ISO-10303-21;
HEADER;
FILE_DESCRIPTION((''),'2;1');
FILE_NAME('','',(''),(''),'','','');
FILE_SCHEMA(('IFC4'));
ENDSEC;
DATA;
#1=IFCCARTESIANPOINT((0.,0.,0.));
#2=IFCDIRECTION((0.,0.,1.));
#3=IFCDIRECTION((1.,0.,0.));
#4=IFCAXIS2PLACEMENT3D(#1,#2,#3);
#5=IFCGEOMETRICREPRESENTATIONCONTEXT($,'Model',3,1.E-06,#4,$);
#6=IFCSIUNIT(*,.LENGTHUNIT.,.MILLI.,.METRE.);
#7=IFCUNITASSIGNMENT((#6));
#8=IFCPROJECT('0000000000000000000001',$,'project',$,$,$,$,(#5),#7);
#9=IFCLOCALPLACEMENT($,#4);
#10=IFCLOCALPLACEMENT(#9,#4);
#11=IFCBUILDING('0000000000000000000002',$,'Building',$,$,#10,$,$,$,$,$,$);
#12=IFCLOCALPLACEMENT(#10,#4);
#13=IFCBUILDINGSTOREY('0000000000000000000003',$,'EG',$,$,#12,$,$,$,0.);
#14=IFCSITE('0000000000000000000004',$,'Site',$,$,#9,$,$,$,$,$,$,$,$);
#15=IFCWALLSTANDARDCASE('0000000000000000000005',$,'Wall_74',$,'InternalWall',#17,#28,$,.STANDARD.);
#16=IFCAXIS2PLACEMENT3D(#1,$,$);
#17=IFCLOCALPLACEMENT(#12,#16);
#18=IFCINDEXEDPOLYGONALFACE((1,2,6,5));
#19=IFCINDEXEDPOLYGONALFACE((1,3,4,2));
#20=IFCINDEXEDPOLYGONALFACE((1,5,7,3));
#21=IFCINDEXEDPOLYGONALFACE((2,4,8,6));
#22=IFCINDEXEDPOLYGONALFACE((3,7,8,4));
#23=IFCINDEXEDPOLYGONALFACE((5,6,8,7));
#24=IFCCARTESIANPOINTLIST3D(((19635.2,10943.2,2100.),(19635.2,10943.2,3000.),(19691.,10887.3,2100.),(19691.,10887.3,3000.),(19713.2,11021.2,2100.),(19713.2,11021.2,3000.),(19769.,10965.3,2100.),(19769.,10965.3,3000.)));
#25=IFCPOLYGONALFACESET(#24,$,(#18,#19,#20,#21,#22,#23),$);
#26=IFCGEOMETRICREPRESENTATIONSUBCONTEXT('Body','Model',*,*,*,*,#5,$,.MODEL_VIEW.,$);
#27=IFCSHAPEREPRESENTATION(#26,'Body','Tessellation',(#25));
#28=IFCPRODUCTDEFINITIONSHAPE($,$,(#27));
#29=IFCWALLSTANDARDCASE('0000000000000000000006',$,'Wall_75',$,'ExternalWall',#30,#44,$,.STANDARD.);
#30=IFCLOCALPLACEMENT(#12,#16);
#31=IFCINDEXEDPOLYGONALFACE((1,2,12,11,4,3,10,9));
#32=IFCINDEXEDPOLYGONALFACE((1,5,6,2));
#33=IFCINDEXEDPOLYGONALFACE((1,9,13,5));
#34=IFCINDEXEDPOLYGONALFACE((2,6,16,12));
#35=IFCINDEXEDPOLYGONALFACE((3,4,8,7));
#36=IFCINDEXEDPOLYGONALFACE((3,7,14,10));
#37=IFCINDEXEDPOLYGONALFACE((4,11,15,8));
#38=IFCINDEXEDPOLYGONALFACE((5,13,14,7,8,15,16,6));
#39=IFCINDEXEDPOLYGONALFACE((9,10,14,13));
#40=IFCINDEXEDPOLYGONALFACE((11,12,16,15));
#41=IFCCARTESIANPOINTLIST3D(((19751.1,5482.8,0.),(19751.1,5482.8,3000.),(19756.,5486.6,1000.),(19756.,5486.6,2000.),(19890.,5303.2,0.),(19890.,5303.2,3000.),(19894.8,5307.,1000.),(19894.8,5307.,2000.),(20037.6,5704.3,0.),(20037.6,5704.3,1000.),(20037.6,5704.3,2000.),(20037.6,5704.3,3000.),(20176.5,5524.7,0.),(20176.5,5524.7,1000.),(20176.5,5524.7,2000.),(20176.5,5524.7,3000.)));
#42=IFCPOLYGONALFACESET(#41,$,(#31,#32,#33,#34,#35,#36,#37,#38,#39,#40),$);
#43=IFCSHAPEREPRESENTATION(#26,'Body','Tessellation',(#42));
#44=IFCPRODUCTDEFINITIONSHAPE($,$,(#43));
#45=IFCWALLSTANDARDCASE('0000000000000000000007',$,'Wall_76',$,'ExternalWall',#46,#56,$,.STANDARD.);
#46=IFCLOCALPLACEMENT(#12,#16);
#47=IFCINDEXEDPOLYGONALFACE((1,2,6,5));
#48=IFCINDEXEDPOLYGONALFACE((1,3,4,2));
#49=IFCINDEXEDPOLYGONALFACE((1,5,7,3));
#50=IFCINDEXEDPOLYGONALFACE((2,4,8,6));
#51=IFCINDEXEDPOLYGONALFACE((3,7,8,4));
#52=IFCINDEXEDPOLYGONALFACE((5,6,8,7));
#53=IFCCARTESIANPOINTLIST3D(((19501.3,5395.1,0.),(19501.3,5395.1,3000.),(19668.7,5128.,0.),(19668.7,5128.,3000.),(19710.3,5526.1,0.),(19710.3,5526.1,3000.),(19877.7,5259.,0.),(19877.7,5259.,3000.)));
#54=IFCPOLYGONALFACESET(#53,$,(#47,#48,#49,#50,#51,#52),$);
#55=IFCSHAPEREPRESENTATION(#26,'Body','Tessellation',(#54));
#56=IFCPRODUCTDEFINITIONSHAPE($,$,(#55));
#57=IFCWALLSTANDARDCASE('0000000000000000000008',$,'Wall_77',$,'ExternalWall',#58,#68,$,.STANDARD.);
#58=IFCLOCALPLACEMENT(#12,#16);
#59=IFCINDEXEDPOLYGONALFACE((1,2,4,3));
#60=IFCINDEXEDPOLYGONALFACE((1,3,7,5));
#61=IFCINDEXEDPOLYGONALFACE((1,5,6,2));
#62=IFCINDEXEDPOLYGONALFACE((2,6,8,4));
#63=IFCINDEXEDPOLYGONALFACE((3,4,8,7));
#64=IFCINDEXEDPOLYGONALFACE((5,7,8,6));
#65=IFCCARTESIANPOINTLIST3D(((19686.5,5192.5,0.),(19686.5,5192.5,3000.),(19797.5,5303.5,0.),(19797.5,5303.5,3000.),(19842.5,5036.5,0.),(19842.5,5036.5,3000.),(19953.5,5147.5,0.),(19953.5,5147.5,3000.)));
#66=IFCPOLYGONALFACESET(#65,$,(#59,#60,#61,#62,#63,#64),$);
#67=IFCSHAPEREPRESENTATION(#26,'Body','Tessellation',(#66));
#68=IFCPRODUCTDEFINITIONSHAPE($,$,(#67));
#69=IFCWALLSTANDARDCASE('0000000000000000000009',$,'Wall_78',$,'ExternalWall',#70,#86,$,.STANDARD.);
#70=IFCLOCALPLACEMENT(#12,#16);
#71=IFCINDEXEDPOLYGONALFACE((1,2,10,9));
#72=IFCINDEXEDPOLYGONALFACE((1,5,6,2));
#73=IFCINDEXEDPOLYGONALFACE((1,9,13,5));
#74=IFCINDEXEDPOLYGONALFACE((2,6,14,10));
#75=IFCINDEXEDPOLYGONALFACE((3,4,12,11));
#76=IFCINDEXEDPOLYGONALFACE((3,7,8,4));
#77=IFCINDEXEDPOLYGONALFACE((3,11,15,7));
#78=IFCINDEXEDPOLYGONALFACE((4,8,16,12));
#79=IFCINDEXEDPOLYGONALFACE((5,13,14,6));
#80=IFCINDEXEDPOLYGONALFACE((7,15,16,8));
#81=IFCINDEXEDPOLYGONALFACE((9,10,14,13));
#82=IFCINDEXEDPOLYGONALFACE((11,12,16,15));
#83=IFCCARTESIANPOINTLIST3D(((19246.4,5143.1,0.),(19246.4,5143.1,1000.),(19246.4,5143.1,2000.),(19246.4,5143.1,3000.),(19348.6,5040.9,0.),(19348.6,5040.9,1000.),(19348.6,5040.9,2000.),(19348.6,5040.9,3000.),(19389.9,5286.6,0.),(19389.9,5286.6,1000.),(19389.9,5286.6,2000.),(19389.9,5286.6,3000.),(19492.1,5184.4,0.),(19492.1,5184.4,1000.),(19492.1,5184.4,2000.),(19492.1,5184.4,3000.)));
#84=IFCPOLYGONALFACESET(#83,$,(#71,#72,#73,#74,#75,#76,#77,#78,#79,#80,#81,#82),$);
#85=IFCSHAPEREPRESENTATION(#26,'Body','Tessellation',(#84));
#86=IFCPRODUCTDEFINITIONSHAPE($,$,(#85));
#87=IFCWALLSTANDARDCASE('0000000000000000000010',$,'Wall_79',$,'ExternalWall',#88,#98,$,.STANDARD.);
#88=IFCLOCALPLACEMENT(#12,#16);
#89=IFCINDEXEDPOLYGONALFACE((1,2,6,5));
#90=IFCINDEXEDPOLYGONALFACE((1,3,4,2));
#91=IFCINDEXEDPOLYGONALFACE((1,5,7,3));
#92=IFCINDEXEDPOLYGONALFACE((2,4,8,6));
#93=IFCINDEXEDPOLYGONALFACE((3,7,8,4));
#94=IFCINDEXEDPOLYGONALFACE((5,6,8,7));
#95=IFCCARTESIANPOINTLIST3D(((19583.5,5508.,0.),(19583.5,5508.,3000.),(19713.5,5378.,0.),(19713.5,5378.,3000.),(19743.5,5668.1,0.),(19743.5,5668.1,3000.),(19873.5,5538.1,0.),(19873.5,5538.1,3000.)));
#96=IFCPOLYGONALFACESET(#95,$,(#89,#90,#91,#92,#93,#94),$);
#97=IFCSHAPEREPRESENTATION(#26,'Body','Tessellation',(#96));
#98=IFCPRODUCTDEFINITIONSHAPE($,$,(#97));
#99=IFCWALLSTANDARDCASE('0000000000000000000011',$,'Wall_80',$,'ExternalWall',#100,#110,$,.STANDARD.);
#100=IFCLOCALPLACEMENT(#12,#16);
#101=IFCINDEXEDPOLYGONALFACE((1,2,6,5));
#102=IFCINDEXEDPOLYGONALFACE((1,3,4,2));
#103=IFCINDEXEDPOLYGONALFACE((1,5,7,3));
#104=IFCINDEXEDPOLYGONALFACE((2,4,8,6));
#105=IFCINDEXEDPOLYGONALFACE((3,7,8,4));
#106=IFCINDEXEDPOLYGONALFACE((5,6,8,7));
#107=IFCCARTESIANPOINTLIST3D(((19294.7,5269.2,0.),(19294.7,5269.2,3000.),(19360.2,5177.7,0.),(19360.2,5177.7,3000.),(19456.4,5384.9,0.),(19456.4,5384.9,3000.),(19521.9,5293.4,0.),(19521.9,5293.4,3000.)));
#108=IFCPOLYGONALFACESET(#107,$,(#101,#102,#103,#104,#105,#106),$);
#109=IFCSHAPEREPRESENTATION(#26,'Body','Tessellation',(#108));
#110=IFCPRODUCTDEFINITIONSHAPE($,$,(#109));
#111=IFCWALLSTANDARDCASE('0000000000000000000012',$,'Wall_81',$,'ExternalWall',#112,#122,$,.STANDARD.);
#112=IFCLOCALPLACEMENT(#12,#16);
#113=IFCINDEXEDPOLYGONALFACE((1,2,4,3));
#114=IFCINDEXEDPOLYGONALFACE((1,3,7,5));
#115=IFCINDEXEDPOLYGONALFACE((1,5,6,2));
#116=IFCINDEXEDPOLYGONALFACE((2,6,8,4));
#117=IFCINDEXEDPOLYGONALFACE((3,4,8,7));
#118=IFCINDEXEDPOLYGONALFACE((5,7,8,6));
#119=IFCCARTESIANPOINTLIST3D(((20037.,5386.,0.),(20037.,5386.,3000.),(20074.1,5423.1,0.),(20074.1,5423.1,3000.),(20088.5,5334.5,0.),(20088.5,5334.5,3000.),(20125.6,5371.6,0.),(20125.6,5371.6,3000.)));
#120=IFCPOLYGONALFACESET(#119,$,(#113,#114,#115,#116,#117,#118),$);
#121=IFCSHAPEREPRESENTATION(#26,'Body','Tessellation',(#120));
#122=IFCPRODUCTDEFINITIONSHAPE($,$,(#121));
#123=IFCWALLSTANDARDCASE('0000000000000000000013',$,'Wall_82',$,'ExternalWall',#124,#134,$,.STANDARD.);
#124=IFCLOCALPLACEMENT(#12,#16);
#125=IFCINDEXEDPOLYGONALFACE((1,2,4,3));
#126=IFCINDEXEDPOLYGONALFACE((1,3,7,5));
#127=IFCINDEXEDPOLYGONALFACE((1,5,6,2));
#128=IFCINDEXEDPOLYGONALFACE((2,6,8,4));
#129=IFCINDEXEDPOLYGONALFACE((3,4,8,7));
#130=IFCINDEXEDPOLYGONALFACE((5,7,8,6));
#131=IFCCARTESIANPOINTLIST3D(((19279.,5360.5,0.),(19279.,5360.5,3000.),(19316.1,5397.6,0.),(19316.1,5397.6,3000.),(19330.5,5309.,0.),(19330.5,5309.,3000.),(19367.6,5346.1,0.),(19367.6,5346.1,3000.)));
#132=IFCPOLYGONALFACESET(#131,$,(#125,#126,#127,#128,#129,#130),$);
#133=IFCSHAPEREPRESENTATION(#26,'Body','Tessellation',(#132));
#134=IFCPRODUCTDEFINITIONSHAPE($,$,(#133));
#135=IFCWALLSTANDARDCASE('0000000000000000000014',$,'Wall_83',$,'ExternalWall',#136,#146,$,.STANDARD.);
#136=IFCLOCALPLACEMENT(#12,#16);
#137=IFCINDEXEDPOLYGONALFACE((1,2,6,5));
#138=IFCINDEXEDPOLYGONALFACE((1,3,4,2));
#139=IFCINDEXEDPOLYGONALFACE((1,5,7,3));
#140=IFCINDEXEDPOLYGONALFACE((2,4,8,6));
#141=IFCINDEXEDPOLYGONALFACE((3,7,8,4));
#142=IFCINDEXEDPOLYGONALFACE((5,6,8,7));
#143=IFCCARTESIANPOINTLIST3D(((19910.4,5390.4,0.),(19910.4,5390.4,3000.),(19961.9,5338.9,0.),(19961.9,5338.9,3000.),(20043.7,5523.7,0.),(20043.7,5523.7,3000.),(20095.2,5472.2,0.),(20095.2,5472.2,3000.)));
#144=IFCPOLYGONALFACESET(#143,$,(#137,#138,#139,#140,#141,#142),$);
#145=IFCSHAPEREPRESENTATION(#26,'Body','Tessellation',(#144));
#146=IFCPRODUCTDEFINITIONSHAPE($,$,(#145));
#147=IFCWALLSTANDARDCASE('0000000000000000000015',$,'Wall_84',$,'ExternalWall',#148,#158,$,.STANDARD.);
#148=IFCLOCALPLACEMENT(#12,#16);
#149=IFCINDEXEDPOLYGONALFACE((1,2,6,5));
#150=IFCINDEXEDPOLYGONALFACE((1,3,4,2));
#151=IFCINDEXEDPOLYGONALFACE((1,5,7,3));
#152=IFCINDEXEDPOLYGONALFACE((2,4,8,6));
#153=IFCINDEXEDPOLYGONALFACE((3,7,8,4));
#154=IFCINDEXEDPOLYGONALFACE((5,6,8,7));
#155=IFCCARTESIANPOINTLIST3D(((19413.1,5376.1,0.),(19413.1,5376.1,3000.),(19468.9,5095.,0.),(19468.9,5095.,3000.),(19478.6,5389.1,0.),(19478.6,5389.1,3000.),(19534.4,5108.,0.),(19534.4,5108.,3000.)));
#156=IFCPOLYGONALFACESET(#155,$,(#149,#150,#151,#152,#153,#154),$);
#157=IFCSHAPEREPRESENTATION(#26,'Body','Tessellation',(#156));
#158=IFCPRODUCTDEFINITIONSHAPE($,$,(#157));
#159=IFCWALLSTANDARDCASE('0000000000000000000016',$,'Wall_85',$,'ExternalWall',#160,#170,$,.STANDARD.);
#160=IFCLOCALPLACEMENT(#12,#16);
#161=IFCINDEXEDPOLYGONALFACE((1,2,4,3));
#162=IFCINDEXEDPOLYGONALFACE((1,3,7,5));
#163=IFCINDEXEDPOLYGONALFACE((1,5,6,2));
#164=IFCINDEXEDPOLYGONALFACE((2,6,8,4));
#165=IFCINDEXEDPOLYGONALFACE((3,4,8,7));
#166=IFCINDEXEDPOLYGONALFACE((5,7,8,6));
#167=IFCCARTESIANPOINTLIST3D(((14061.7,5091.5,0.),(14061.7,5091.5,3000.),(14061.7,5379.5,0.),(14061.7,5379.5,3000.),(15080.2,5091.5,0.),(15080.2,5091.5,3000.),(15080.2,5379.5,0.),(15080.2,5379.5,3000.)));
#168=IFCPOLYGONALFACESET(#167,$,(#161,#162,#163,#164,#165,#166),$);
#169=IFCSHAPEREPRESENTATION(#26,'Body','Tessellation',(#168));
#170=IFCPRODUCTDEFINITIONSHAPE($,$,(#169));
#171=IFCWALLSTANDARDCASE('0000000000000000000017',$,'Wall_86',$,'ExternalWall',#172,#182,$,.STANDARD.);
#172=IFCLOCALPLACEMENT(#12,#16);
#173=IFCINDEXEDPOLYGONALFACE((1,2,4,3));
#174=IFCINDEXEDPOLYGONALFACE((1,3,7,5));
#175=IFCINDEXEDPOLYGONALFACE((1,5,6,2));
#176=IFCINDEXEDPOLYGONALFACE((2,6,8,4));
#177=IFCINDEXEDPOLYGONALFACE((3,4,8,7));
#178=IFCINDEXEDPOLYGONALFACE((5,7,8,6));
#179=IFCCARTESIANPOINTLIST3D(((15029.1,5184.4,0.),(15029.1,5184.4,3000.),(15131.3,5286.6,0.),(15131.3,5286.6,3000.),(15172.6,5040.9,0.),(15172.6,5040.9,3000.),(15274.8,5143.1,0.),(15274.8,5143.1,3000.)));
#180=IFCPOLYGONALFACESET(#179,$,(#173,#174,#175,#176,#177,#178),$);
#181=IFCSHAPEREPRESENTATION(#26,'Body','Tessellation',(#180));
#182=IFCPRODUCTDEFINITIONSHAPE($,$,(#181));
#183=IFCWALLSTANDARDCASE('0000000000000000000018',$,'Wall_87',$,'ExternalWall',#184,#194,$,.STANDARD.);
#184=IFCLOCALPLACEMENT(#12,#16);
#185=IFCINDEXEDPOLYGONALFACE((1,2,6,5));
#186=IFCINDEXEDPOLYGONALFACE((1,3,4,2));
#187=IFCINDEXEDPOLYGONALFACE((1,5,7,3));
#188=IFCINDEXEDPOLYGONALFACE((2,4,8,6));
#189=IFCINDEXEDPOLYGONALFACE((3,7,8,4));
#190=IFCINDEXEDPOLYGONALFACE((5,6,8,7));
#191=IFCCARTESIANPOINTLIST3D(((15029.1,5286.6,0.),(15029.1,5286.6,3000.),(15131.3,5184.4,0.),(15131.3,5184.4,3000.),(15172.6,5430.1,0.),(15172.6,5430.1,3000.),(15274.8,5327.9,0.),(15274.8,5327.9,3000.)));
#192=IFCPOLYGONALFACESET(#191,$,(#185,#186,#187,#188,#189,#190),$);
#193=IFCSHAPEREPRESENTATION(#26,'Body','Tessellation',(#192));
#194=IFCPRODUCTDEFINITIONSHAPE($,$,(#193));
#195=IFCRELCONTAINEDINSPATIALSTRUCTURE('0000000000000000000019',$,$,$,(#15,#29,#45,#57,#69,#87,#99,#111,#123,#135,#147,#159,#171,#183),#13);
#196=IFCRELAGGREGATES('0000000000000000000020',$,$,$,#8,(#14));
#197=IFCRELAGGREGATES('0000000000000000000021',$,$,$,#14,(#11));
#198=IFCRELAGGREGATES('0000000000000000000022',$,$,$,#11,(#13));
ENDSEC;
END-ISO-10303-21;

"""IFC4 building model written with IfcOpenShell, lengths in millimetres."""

from ifc_helpers import new_model, si_unit, frame, origin_with_axes, place, context, subcontext, project, spatial, rectangle, extrude, element, save


model = new_model("IFC4")

# Units and contexts
model_context = context("Model", 3, precision=1e-06, world=origin_with_axes())
body_context = subcontext(model_context, "Body", "Model", "MODEL_VIEW")
ifc_project = project(units=[si_unit("LENGTHUNIT", "METRE", prefix="MILLI")], contexts=[model_context])

# Site, building, storey
site_placement = place(None, origin_with_axes())
site = spatial("IfcSite", under=ifc_project, at=site_placement, Name="Site")
building_placement = place(site_placement, origin_with_axes())
building = spatial("IfcBuilding", under=site, at=building_placement, Name="Building")
storey_placement = place(building_placement, origin_with_axes())
storey = spatial("IfcBuildingStorey", under=building, at=storey_placement, Name="EG", Elevation=0.0)

# Walls, openings
wall_1_placement = place(storey_placement, origin_with_axes())
wall_1 = element("IfcWallStandardCase", 1, at=wall_1_placement, inside=storey, Name="Wall_74", ObjectType="InternalWall", PredefinedType="STANDARD", context=body_context, shape_type="SweptSolid", body=[
    extrude(rectangle(XDim=110.3, YDim=79.0), frame((19702.1, 10954.2, 0.0), z_axis=(0.0, 0.0, 1.0), x_axis=(-0.707107, -0.707107, 0.0)), (0.0, 0.0, 1.0), 3000.0),
])
opening_1_placement = place(wall_1_placement, origin_with_axes())
element("IfcOpeningElement", 2, at=opening_1_placement, inside=storey, cuts=wall_1, context=body_context, shape_type="SweptSolid", body=[
    extrude(rectangle(XDim=450.0, YDim=79.0), frame((19702.1, 10954.2, 0.0), z_axis=(0.0, 0.0, 1.0), x_axis=(-0.707107, -0.707107, 0.0)), (0.0, 0.0, 1.0), 2100.0),
])
wall_2_placement = place(storey_placement, origin_with_axes())
wall_2 = element("IfcWallStandardCase", 3, at=wall_2_placement, inside=storey, Name="Wall_75", ObjectType="ExternalWall", PredefinedType="STANDARD", context=body_context, shape_type="SweptSolid", body=[
    extrude(rectangle(XDim=362.1, YDim=227.0), frame((19963.8, 5503.8, 0.0), z_axis=(0.0, 0.0, 1.0), x_axis=(-0.791133, -0.611644, 0.0)), (0.0, 0.0, 1.0), 3000.0),
])
opening_2_placement = place(wall_2_placement, origin_with_axes())
element("IfcOpeningElement", 4, at=opening_2_placement, inside=storey, cuts=wall_2, context=body_context, shape_type="SweptSolid", body=[
    extrude(rectangle(XDim=600.0, YDim=227.0), frame((20062.7, 5580.3, 1000.0), z_axis=(0.0, 0.0, 1.0), x_axis=(-0.791133, -0.611644, 0.0)), (0.0, 0.0, 1.0), 1000.0),
])

# Walls
wall_3_placement = place(storey_placement, origin_with_axes())
element("IfcWallStandardCase", 5, at=wall_3_placement, inside=storey, Name="Wall_76", ObjectType="ExternalWall", PredefinedType="STANDARD", context=body_context, shape_type="SweptSolid", body=[
    extrude(rectangle(XDim=246.7, YDim=315.3), frame((19689.5, 5327.0, 0.0), z_axis=(0.0, 0.0, 1.0), x_axis=(0.847314, 0.531092, 0.0)), (0.0, 0.0, 1.0), 3000.0),
])
wall_4_placement = place(storey_placement, origin_with_axes())
element("IfcWallStandardCase", 6, at=wall_4_placement, inside=storey, Name="Wall_77", ObjectType="ExternalWall", PredefinedType="STANDARD", context=body_context, shape_type="SweptSolid", body=[
    extrude(rectangle(XDim=220.6, YDim=157.0), frame((19820.0, 5170.0, 0.0), z_axis=(0.0, 0.0, 1.0), x_axis=(0.707107, -0.707107, 0.0)), (0.0, 0.0, 1.0), 3000.0),
])

# Wall, opening
wall_5_placement = place(storey_placement, origin_with_axes())
wall_5 = element("IfcWallStandardCase", 7, at=wall_5_placement, inside=storey, Name="Wall_78", ObjectType="ExternalWall", PredefinedType="STANDARD", context=body_context, shape_type="SweptSolid", body=[
    extrude(rectangle(XDim=202.9, YDim=144.5), frame((19369.3, 5163.8, 0.0), z_axis=(0.0, 0.0, 1.0), x_axis=(-0.707107, -0.707107, 0.0)), (0.0, 0.0, 1.0), 3000.0),
])
opening_3_placement = place(wall_5_placement, origin_with_axes())
element("IfcOpeningElement", 8, at=opening_3_placement, inside=storey, cuts=wall_5, context=body_context, shape_type="SweptSolid", body=[
    extrude(rectangle(XDim=600.0, YDim=144.5), frame((19349.7, 5144.3, 1000.0), z_axis=(0.0, 0.0, 1.0), x_axis=(-0.707107, -0.707107, 0.0)), (0.0, 0.0, 1.0), 1000.0),
])

# Walls
wall_6_placement = place(storey_placement, origin_with_axes())
element("IfcWallStandardCase", 9, at=wall_6_placement, inside=storey, Name="Wall_79", ObjectType="ExternalWall", PredefinedType="STANDARD", context=body_context, shape_type="SweptSolid", body=[
    extrude(rectangle(XDim=183.8, YDim=226.4), frame((19728.5, 5523.0, 0.0), z_axis=(0.0, 0.0, 1.0), x_axis=(0.707107, -0.707107, 0.0)), (0.0, 0.0, 1.0), 3000.0),
])
wall_7_placement = place(storey_placement, origin_with_axes())
element("IfcWallStandardCase", 10, at=wall_7_placement, inside=storey, Name="Wall_80", ObjectType="ExternalWall", PredefinedType="STANDARD", context=body_context, shape_type="SweptSolid", body=[
    extrude(rectangle(XDim=112.5, YDim=198.8), frame((19408.3, 5281.3, 0.0), z_axis=(0.0, 0.0, 1.0), x_axis=(-0.582079, 0.813133, 0.0)), (0.0, 0.0, 1.0), 3000.0),
])
wall_8_placement = place(storey_placement, origin_with_axes())
element("IfcWallStandardCase", 11, at=wall_8_placement, inside=storey, Name="Wall_81", ObjectType="ExternalWall", PredefinedType="STANDARD", context=body_context, shape_type="SweptSolid", body=[
    extrude(rectangle(XDim=72.8, YDim=52.5), frame((20081.3, 5378.8, 0.0), z_axis=(0.0, 0.0, 1.0), x_axis=(0.707107, -0.707107, 0.0)), (0.0, 0.0, 1.0), 3000.0),
])
wall_9_placement = place(storey_placement, origin_with_axes())
element("IfcWallStandardCase", 12, at=wall_9_placement, inside=storey, Name="Wall_82", ObjectType="ExternalWall", PredefinedType="STANDARD", context=body_context, shape_type="SweptSolid", body=[
    extrude(rectangle(XDim=72.8, YDim=52.5), frame((19323.3, 5353.3, 0.0), z_axis=(0.0, 0.0, 1.0), x_axis=(0.707107, -0.707107, 0.0)), (0.0, 0.0, 1.0), 3000.0),
])
wall_10_placement = place(storey_placement, origin_with_axes())
element("IfcWallStandardCase", 13, at=wall_10_placement, inside=storey, Name="Wall_83", ObjectType="ExternalWall", PredefinedType="STANDARD", context=body_context, shape_type="SweptSolid", body=[
    extrude(rectangle(XDim=72.8, YDim=188.5), frame((20002.8, 5431.3, 0.0), z_axis=(0.0, 0.0, 1.0), x_axis=(0.707107, -0.707107, 0.0)), (0.0, 0.0, 1.0), 3000.0),
])
wall_11_placement = place(storey_placement, origin_with_axes())
element("IfcWallStandardCase", 14, at=wall_11_placement, inside=storey, Name="Wall_84", ObjectType="ExternalWall", PredefinedType="STANDARD", context=body_context, shape_type="SweptSolid", body=[
    extrude(rectangle(XDim=66.8, YDim=286.6), frame((19473.8, 5242.0, 0.0), z_axis=(0.0, 0.0, 1.0), x_axis=(0.980868, 0.194676, 0.0)), (0.0, 0.0, 1.0), 3000.0),
])
wall_12_placement = place(storey_placement, origin_with_axes())
element("IfcWallStandardCase", 15, at=wall_12_placement, inside=storey, Name="Wall_85", ObjectType="ExternalWall", PredefinedType="STANDARD", context=body_context, shape_type="SweptSolid", body=[
    extrude(rectangle(XDim=1018.5, YDim=288.0), frame((14571.0, 5235.5, 0.0), z_axis=(0.0, 0.0, 1.0), x_axis=(-1.0, 0.0, 0.0)), (0.0, 0.0, 1.0), 3000.0),
])
wall_13_placement = place(storey_placement, origin_with_axes())
element("IfcWallStandardCase", 16, at=wall_13_placement, inside=storey, Name="Wall_86", ObjectType="ExternalWall", PredefinedType="STANDARD", context=body_context, shape_type="SweptSolid", body=[
    extrude(rectangle(XDim=202.9, YDim=144.5), frame((15152.0, 5163.8, 0.0), z_axis=(0.0, 0.0, 1.0), x_axis=(0.707107, -0.707107, 0.0)), (0.0, 0.0, 1.0), 3000.0),
])
wall_14_placement = place(storey_placement, origin_with_axes())
element("IfcWallStandardCase", 17, at=wall_14_placement, inside=storey, Name="Wall_87", ObjectType="ExternalWall", PredefinedType="STANDARD", context=body_context, shape_type="SweptSolid", body=[
    extrude(rectangle(XDim=202.9, YDim=144.5), frame((15152.0, 5307.3, 0.0), z_axis=(0.0, 0.0, 1.0), x_axis=(0.707107, 0.707107, 0.0)), (0.0, 0.0, 1.0), 3000.0),
])

save(model, "model.ifc")
